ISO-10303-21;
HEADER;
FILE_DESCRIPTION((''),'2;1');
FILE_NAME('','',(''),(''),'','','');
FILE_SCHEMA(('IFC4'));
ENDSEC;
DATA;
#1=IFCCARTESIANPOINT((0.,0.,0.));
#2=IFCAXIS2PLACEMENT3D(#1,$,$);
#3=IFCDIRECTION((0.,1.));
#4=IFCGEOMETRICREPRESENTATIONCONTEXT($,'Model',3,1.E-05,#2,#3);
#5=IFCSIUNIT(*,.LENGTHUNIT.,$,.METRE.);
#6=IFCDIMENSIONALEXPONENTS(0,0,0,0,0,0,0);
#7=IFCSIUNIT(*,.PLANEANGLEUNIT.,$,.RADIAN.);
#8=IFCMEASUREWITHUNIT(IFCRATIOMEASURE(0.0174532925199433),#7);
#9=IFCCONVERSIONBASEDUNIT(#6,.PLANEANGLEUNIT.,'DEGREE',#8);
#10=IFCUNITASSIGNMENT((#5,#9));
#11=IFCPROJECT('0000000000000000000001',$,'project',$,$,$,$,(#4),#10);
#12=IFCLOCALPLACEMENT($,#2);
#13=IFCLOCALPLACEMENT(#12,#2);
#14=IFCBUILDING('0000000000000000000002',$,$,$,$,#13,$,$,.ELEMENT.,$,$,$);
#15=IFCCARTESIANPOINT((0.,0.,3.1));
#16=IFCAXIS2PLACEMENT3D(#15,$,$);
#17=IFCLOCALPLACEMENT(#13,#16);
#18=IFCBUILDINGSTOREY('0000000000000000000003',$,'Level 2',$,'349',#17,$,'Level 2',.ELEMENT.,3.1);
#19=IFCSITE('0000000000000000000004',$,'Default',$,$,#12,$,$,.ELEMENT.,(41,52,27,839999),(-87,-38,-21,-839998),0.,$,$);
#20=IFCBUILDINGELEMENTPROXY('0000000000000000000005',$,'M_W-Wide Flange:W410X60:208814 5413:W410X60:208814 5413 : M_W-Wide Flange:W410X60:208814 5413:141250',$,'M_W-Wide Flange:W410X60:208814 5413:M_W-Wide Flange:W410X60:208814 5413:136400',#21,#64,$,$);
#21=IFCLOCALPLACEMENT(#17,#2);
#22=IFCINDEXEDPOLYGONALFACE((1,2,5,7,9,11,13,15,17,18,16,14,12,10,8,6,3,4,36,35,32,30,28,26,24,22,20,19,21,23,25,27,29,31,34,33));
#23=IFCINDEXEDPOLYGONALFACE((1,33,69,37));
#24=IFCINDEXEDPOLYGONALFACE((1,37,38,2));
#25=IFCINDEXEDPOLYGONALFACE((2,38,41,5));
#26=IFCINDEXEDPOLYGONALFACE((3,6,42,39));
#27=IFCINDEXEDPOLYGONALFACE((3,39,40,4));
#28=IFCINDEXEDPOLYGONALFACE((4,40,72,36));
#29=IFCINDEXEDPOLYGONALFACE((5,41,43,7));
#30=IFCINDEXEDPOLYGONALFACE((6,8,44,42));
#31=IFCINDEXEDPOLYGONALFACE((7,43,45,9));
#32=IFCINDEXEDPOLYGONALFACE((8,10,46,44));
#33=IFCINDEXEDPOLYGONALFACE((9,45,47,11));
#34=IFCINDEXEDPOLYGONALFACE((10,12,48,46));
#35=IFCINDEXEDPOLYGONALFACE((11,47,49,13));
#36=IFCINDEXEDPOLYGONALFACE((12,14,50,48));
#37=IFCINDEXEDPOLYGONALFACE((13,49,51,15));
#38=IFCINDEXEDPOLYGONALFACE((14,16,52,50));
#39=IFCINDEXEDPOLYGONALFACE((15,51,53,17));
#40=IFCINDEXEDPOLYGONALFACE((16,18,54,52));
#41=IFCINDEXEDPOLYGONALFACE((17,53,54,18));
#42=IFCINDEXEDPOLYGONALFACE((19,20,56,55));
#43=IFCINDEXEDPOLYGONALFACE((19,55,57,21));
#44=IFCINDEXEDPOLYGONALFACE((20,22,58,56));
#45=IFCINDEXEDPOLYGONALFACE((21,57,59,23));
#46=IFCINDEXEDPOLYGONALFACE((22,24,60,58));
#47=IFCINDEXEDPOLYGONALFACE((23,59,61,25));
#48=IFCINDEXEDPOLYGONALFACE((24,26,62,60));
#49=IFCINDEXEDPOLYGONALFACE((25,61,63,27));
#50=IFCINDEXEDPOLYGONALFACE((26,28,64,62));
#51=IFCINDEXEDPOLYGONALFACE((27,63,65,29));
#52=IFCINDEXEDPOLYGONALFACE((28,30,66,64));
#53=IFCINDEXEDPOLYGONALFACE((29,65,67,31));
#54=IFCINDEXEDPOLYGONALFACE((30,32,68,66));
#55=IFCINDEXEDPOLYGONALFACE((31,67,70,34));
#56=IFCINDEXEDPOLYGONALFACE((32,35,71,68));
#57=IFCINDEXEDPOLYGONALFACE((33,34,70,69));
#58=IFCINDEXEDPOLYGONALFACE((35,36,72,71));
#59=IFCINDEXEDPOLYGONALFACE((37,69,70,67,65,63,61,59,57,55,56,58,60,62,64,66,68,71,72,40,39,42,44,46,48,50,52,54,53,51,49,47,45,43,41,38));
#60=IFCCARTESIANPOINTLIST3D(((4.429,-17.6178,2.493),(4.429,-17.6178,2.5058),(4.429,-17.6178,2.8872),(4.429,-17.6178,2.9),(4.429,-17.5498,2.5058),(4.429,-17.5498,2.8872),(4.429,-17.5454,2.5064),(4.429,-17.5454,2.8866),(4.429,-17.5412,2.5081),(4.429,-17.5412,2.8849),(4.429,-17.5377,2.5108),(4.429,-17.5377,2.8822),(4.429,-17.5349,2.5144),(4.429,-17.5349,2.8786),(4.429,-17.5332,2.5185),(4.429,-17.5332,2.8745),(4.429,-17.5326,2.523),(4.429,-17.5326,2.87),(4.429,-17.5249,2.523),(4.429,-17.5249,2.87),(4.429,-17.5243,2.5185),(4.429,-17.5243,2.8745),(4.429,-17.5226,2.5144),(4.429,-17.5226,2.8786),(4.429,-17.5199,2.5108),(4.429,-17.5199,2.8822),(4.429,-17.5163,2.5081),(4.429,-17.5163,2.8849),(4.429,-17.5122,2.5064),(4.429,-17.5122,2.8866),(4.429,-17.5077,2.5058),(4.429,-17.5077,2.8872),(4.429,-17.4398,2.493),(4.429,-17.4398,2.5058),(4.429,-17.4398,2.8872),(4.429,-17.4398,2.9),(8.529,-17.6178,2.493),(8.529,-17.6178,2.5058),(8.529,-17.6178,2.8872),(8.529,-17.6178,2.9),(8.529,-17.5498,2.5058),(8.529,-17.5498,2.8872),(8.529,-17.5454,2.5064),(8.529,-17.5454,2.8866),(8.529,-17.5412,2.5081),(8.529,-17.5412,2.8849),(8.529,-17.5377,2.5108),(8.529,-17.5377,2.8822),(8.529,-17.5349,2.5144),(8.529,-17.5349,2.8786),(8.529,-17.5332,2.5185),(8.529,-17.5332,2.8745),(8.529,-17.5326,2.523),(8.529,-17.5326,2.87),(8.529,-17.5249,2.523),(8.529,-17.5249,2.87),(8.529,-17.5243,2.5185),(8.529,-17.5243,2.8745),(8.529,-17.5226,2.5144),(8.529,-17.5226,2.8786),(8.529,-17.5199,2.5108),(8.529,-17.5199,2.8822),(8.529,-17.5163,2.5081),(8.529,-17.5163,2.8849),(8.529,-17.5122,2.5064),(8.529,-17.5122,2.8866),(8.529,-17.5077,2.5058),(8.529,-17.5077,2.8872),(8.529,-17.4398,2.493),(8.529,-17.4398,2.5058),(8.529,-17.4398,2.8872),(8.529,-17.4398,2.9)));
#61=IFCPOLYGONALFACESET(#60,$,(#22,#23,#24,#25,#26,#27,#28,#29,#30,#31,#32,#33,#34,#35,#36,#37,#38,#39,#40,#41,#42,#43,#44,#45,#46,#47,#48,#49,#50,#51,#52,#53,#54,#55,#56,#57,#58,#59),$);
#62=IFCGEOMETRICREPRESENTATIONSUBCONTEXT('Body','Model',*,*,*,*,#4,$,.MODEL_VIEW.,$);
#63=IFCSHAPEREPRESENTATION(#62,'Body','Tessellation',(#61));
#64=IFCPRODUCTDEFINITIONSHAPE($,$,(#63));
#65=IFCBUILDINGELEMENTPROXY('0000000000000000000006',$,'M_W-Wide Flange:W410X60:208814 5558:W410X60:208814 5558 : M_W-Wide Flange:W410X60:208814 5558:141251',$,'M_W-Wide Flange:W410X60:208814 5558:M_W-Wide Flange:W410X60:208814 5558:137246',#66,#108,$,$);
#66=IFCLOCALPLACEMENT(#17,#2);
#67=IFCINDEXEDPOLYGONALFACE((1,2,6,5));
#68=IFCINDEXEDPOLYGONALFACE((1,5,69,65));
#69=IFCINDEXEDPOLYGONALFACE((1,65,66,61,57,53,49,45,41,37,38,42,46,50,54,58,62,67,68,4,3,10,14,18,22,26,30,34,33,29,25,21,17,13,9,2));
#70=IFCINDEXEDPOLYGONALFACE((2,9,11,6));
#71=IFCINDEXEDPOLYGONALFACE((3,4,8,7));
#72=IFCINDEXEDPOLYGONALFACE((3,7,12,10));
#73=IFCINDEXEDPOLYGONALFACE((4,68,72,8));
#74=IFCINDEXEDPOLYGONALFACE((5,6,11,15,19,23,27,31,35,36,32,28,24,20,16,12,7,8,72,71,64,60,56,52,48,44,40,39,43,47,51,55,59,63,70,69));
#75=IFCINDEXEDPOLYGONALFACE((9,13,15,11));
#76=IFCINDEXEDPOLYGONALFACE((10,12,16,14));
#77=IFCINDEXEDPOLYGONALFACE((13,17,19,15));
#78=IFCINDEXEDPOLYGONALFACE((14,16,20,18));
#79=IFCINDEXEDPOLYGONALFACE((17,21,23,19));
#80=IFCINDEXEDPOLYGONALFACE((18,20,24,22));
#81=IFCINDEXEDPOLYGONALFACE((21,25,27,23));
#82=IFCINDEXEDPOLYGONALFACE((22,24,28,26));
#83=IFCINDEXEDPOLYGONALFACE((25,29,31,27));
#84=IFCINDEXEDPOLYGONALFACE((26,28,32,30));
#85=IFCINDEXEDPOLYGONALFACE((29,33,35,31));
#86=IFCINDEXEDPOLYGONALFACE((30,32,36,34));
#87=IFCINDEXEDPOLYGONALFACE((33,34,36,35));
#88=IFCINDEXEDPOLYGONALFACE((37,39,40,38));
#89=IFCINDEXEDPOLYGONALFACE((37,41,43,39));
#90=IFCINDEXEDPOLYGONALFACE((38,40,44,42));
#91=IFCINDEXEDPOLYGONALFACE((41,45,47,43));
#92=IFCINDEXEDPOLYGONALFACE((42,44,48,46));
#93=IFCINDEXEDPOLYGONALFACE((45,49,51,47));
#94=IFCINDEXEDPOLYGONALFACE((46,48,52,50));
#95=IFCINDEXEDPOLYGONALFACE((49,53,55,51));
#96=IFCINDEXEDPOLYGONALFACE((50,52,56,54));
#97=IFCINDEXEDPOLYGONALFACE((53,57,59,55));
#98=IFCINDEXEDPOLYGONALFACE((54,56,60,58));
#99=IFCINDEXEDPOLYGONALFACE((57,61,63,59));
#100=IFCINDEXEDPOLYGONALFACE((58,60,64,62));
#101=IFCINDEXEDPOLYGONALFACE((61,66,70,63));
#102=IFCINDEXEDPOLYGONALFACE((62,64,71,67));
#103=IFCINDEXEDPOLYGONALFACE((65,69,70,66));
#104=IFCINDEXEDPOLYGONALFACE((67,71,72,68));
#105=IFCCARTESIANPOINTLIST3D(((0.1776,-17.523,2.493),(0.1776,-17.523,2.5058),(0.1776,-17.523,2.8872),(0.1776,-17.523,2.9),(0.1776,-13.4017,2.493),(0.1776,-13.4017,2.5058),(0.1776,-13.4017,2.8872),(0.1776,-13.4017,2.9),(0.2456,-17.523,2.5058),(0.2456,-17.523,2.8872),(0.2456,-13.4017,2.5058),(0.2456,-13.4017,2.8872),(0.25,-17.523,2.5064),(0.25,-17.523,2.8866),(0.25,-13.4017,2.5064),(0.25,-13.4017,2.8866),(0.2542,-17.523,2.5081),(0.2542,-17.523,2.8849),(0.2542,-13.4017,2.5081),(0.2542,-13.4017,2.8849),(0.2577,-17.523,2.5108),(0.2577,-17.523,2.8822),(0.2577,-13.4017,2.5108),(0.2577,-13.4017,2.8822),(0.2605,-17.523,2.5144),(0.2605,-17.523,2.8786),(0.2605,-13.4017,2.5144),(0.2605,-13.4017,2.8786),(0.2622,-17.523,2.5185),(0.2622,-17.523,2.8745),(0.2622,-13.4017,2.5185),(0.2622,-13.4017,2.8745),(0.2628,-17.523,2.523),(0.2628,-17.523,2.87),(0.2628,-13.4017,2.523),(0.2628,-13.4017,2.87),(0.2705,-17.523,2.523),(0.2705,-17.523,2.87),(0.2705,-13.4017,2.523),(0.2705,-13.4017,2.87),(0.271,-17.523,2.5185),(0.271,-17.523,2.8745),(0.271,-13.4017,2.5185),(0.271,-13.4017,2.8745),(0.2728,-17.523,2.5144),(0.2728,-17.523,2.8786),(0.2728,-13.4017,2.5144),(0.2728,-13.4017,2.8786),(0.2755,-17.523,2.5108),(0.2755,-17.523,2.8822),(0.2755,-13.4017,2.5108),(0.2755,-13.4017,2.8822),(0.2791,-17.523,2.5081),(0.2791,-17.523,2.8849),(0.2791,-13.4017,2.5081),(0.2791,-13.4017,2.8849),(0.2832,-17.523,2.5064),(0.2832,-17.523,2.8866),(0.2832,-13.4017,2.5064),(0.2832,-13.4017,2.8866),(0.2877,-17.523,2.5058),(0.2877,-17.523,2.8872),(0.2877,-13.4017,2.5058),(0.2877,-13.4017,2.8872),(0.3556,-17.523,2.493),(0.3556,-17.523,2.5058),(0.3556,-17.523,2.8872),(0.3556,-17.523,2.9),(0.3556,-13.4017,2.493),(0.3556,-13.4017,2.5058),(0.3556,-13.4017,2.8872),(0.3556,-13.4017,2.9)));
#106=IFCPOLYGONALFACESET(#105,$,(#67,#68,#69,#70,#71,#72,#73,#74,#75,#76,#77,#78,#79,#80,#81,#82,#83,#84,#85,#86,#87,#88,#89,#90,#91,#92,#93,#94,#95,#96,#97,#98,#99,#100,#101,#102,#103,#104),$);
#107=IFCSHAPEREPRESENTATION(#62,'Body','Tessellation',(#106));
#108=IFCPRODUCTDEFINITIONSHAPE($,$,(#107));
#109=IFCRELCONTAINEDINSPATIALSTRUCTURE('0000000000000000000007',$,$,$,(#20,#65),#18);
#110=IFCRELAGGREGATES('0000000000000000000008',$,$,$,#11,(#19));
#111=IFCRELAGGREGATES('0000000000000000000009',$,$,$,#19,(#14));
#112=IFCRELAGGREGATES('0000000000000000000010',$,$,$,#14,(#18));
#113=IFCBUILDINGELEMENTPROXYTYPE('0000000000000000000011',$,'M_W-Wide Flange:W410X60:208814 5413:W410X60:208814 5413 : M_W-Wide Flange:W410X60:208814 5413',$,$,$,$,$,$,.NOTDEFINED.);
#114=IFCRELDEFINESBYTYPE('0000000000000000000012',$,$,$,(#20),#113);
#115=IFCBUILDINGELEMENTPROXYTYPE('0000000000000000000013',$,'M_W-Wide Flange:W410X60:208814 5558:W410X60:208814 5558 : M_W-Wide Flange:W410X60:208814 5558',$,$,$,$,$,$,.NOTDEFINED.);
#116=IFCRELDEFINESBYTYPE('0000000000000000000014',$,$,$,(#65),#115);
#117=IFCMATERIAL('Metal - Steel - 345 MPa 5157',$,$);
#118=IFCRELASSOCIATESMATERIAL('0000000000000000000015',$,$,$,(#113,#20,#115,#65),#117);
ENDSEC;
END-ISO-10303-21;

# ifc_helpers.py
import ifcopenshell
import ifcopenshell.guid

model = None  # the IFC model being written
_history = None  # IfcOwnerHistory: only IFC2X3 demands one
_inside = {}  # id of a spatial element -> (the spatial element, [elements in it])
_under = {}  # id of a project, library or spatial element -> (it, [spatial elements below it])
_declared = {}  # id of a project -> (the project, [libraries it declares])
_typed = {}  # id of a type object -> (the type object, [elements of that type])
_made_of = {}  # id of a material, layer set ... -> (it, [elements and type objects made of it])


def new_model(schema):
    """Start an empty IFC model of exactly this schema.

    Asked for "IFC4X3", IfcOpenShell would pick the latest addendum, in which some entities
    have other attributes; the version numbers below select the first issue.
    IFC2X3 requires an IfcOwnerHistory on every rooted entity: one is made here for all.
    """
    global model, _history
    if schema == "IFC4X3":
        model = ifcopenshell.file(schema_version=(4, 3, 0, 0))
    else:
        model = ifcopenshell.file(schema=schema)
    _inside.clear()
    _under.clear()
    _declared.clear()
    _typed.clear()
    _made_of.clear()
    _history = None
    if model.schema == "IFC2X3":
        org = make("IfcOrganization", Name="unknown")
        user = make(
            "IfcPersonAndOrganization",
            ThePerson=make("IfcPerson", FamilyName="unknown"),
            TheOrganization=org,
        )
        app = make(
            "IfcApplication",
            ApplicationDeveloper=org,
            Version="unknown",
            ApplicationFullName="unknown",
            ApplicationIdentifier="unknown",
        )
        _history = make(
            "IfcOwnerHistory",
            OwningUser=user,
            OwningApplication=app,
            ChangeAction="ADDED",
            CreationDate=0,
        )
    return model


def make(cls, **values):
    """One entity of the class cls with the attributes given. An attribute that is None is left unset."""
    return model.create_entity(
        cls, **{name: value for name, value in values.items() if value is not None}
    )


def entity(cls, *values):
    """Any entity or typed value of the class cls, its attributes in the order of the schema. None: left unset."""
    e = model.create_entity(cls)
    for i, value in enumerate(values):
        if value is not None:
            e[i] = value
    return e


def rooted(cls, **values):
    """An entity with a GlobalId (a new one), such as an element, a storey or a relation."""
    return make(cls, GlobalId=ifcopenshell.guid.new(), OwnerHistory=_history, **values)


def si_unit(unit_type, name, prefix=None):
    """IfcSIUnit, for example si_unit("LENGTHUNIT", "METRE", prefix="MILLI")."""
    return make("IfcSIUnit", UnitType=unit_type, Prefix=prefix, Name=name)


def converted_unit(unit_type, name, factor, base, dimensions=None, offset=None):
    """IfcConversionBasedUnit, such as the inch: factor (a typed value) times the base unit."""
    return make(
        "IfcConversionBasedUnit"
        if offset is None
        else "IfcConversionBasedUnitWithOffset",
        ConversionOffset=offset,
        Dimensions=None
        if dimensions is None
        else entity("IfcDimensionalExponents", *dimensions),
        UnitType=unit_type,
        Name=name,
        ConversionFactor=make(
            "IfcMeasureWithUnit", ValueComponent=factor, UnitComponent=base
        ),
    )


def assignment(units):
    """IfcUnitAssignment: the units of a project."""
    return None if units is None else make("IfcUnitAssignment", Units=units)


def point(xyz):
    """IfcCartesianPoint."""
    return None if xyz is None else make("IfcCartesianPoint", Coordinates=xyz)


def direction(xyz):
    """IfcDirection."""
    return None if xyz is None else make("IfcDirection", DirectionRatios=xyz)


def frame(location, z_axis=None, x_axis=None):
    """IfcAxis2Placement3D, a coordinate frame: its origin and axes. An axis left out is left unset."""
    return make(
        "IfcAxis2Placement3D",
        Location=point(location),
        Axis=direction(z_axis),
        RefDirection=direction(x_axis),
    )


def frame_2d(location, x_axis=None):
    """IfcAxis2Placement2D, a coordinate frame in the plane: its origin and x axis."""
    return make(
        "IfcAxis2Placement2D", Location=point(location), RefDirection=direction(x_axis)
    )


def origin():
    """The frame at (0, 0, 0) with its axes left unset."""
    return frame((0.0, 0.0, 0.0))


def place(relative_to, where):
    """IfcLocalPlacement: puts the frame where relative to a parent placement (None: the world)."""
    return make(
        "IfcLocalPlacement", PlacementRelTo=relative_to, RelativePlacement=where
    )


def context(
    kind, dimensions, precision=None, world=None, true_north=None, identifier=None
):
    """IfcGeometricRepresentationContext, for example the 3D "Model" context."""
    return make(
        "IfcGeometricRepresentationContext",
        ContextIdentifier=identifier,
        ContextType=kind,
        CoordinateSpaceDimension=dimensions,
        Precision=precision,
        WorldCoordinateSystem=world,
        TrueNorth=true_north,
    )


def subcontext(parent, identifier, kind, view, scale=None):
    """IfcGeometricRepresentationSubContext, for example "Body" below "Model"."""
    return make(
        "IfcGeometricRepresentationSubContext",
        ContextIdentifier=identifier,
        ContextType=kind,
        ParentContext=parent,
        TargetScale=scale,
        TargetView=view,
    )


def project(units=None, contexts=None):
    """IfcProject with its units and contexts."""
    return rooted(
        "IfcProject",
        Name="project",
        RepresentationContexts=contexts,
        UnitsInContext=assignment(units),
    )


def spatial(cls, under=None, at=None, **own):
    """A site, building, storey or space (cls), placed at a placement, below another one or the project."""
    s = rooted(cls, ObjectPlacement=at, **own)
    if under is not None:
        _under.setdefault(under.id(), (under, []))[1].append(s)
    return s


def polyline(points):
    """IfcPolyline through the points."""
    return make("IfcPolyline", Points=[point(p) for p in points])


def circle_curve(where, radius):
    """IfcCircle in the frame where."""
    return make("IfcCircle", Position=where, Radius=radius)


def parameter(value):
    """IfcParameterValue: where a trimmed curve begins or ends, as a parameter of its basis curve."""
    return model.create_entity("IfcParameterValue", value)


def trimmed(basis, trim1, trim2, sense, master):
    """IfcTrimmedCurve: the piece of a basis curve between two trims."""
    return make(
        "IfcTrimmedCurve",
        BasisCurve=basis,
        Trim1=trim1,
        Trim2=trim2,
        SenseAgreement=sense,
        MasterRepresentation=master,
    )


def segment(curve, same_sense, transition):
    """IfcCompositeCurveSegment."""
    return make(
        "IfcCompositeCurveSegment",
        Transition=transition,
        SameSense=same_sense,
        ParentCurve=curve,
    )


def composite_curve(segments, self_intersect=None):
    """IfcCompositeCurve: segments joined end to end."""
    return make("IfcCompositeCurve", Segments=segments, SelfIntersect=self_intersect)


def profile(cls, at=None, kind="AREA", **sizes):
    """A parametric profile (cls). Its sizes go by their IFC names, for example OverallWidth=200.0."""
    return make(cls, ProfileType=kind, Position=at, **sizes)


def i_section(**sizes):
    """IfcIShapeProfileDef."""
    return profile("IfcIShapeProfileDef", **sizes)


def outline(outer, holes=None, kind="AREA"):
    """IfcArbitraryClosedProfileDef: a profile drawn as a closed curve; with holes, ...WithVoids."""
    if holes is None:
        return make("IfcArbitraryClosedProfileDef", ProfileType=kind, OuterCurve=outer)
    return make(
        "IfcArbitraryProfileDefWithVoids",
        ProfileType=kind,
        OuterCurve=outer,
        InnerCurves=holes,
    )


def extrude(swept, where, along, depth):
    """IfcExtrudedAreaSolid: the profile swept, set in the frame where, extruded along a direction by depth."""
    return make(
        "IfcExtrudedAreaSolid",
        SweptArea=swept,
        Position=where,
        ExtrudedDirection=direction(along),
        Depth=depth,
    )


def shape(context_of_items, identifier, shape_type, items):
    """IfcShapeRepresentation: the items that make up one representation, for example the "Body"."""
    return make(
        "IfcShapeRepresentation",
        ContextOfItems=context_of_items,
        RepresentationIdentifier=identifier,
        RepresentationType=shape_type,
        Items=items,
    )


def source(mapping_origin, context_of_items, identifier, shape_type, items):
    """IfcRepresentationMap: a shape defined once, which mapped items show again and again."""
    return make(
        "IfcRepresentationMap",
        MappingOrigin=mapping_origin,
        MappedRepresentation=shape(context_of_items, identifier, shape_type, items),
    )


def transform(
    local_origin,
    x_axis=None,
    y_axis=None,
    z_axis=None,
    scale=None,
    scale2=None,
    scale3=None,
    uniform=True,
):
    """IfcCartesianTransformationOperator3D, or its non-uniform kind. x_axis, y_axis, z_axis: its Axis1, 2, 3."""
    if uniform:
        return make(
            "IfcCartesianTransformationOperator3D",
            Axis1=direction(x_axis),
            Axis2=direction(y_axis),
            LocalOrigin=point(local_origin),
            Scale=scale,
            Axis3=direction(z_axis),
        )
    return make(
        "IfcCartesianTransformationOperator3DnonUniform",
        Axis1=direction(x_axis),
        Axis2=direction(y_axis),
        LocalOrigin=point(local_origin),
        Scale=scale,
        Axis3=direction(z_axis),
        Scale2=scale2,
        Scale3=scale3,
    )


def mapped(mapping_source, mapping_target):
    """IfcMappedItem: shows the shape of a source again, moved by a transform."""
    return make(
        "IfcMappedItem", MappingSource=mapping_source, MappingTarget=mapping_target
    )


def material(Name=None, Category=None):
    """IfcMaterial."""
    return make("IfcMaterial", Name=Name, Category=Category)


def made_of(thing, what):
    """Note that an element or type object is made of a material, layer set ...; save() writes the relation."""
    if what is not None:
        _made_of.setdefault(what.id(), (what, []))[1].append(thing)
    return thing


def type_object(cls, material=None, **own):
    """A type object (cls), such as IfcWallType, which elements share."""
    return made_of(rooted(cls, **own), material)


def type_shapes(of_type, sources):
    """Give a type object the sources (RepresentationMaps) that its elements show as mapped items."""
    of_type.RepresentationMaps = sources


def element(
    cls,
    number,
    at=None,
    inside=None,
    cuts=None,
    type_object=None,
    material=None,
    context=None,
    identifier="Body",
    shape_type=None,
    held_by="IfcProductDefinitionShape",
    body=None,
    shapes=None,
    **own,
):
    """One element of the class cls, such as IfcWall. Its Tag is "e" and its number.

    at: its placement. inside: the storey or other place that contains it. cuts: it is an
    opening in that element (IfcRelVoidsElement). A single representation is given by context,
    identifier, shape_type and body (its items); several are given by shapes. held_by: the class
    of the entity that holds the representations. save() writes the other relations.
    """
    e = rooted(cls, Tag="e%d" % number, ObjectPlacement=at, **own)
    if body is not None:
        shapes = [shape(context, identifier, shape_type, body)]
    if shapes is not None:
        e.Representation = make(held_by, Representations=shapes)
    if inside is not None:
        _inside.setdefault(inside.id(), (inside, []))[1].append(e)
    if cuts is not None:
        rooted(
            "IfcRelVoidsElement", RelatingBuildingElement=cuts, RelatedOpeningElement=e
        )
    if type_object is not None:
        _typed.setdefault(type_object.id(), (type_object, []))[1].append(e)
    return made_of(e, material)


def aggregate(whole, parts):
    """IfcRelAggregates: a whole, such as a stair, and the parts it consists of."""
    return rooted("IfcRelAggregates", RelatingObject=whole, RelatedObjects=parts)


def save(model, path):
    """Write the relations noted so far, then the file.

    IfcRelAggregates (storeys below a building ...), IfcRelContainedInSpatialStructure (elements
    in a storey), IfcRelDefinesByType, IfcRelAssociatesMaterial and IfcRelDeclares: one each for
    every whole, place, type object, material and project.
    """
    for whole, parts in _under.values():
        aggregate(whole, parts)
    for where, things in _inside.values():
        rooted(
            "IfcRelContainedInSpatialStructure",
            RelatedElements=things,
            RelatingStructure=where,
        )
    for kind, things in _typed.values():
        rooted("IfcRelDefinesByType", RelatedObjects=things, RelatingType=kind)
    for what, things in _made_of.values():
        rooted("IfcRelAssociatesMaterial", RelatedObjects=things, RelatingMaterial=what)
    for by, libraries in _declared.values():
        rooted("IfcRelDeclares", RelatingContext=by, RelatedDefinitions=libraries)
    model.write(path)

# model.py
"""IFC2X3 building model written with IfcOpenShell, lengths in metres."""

from ifc_helpers import new_model, entity, si_unit, converted_unit, direction, frame, frame_2d, origin, place, context, subcontext, project, spatial, polyline, circle_curve, parameter, trimmed, segment, composite_curve, i_section, outline, extrude, source, transform, mapped, material, type_object, type_shapes, element, save


model = new_model("IFC2X3")

# Units and contexts
model_context = context("Model", 3, precision=1e-05, world=origin(), true_north=direction((0.0, 1.0)))
body_context = subcontext(model_context, "Body", "Model", "MODEL_VIEW")
ifc_project = project(units=[si_unit("LENGTHUNIT", "METRE"), converted_unit("PLANEANGLEUNIT", "DEGREE", entity("IfcRatioMeasure", 0.0174532925199433), si_unit("PLANEANGLEUNIT", "RADIAN"), dimensions=[0, 0, 0, 0, 0, 0, 0])], contexts=[model_context])

# Site, building, storey
site_placement = place(None, origin())
site = spatial("IfcSite", under=ifc_project, at=site_placement, Name="Default", CompositionType="ELEMENT", RefLatitude=(41, 52, 27, 839999), RefLongitude=(-87, -38, -21, -839998), RefElevation=0.0)
building_placement = place(site_placement, origin())
building = spatial("IfcBuilding", under=site, at=building_placement, CompositionType="ELEMENT")
storey_placement = place(building_placement, frame((0.0, 0.0, 3.1)))
storey = spatial("IfcBuildingStorey", under=building, at=storey_placement, Name="Level 2", ObjectType="349", LongName="Level 2", CompositionType="ELEMENT", Elevation=3.1)

# Building element proxies
ifc_material_1 = material(Name="Metal - Steel - 345 MPa 5157")
building_element_proxy_type_1 = type_object("IfcBuildingElementProxyType", Name="M_W-Wide Flange:W410X60:208814 5413:W410X60:208814 5413 : M_W-Wide Flange:W410X60:208814 5413", PredefinedType="NOTDEFINED", material=ifc_material_1)
shared_shape_1 = source(origin(), body_context, "Body", "SweptSolid", [
    extrude(outline(composite_curve([segment(polyline([(-0.0211, -0.1907), (-0.089, -0.1907)]), True, "CONTINUOUS"), segment(polyline([(-0.089, -0.1907), (-0.089, -0.2035)]), True, "CONTINUOUS"), segment(polyline([(-0.089, -0.2035), (0.089, -0.2035)]), True, "CONTINUOUS"), segment(polyline([(0.089, -0.2035), (0.089, -0.1907)]), True, "CONTINUOUS"), segment(polyline([(0.089, -0.1907), (0.0211, -0.1907)]), True, "CONTINUOUS"), segment(trimmed(circle_curve(frame_2d((0.0211, -0.1735), x_axis=(0.0, -1.0)), 0.0172), [parameter(270.0)], [parameter(360.0)], True, "PARAMETER"), False, "CONTINUOUS"), segment(polyline([(0.0039, -0.1735), (0.0039, 0.1735)]), True, "CONTINUOUS"), segment(trimmed(circle_curve(frame_2d((0.0211, 0.1735), x_axis=(-1.0, 0.0)), 0.0172), [parameter(270.0)], [parameter(360.0)], True, "PARAMETER"), False, "CONTINUOUS"), segment(polyline([(0.0211, 0.1907), (0.089, 0.1907)]), True, "CONTINUOUS"), segment(polyline([(0.089, 0.1907), (0.089, 0.2035)]), True, "CONTINUOUS"), segment(polyline([(0.089, 0.2035), (-0.089, 0.2035)]), True, "CONTINUOUS"), segment(polyline([(-0.089, 0.2035), (-0.089, 0.1907)]), True, "CONTINUOUS"), segment(polyline([(-0.089, 0.1907), (-0.0211, 0.1907)]), True, "CONTINUOUS"), segment(trimmed(circle_curve(frame_2d((-0.0211, 0.1735), x_axis=(0.0, 1.0)), 0.0172), [parameter(270.0)], [parameter(360.0)], True, "PARAMETER"), False, "CONTINUOUS"), segment(polyline([(-0.0039, 0.1735), (-0.0039, -0.1735)]), True, "CONTINUOUS"), segment(trimmed(circle_curve(frame_2d((-0.0211, -0.1735), x_axis=(1.0, 0.0)), 0.0172), [parameter(270.0)], [parameter(360.0)], True, "PARAMETER"), False, "CONTINUOUS")], self_intersect=False)), frame((0.0, 0.0, -0.2035), z_axis=(0.0, -1.0, 0.0), x_axis=(1.0, 0.0, 0.0)), (0.0, 0.0, -1.0), 4.1),
])
type_shapes(building_element_proxy_type_1, [shared_shape_1])
proxy_1_placement = place(storey_placement, frame((4.429, -17.5288, 2.9), z_axis=(0.0, 0.0, 1.0), x_axis=(0.0, -1.0, 0.0)))
element("IfcBuildingElementProxy", 1, at=proxy_1_placement, inside=storey, type_object=building_element_proxy_type_1, material=ifc_material_1, Name="M_W-Wide Flange:W410X60:208814 5413:W410X60:208814 5413 : M_W-Wide Flange:W410X60:208814 5413:141250", ObjectType="M_W-Wide Flange:W410X60:208814 5413:M_W-Wide Flange:W410X60:208814 5413:136400", context=body_context, shape_type="MappedRepresentation", body=[
    mapped(shared_shape_1, transform((0.0, 0.0, 0.0), scale=1.0)),
])
building_element_proxy_type_2 = type_object("IfcBuildingElementProxyType", Name="M_W-Wide Flange:W410X60:208814 5558:W410X60:208814 5558 : M_W-Wide Flange:W410X60:208814 5558", PredefinedType="NOTDEFINED", material=ifc_material_1)
shared_shape_2 = source(origin(), body_context, "Body", "SweptSolid", [
    extrude(i_section(OverallWidth=0.178, OverallDepth=0.407, WebThickness=0.0077, FlangeThickness=0.0128, FilletRadius=0.0172, at=frame_2d((0.0, 0.0), x_axis=(0.0, 1.0))), frame((0.0, 0.0, -0.2035), z_axis=(0.0, 1.0, 0.0), x_axis=(0.0, 0.0, 1.0)), (0.0, 0.0, 1.0), 4.1213),
])
type_shapes(building_element_proxy_type_2, [shared_shape_2])
proxy_2_placement = place(storey_placement, frame((0.2666, -13.4017, 2.9), z_axis=(0.0, 0.0, 1.0), x_axis=(-1.0, 0.0, 0.0)))
element("IfcBuildingElementProxy", 2, at=proxy_2_placement, inside=storey, type_object=building_element_proxy_type_2, material=ifc_material_1, Name="M_W-Wide Flange:W410X60:208814 5558:W410X60:208814 5558 : M_W-Wide Flange:W410X60:208814 5558:141251", ObjectType="M_W-Wide Flange:W410X60:208814 5558:M_W-Wide Flange:W410X60:208814 5558:137246", context=body_context, shape_type="MappedRepresentation", body=[
    mapped(shared_shape_2, transform((0.0, 0.0, 0.0), scale=1.0)),
])

save(model, "model.ifc")
